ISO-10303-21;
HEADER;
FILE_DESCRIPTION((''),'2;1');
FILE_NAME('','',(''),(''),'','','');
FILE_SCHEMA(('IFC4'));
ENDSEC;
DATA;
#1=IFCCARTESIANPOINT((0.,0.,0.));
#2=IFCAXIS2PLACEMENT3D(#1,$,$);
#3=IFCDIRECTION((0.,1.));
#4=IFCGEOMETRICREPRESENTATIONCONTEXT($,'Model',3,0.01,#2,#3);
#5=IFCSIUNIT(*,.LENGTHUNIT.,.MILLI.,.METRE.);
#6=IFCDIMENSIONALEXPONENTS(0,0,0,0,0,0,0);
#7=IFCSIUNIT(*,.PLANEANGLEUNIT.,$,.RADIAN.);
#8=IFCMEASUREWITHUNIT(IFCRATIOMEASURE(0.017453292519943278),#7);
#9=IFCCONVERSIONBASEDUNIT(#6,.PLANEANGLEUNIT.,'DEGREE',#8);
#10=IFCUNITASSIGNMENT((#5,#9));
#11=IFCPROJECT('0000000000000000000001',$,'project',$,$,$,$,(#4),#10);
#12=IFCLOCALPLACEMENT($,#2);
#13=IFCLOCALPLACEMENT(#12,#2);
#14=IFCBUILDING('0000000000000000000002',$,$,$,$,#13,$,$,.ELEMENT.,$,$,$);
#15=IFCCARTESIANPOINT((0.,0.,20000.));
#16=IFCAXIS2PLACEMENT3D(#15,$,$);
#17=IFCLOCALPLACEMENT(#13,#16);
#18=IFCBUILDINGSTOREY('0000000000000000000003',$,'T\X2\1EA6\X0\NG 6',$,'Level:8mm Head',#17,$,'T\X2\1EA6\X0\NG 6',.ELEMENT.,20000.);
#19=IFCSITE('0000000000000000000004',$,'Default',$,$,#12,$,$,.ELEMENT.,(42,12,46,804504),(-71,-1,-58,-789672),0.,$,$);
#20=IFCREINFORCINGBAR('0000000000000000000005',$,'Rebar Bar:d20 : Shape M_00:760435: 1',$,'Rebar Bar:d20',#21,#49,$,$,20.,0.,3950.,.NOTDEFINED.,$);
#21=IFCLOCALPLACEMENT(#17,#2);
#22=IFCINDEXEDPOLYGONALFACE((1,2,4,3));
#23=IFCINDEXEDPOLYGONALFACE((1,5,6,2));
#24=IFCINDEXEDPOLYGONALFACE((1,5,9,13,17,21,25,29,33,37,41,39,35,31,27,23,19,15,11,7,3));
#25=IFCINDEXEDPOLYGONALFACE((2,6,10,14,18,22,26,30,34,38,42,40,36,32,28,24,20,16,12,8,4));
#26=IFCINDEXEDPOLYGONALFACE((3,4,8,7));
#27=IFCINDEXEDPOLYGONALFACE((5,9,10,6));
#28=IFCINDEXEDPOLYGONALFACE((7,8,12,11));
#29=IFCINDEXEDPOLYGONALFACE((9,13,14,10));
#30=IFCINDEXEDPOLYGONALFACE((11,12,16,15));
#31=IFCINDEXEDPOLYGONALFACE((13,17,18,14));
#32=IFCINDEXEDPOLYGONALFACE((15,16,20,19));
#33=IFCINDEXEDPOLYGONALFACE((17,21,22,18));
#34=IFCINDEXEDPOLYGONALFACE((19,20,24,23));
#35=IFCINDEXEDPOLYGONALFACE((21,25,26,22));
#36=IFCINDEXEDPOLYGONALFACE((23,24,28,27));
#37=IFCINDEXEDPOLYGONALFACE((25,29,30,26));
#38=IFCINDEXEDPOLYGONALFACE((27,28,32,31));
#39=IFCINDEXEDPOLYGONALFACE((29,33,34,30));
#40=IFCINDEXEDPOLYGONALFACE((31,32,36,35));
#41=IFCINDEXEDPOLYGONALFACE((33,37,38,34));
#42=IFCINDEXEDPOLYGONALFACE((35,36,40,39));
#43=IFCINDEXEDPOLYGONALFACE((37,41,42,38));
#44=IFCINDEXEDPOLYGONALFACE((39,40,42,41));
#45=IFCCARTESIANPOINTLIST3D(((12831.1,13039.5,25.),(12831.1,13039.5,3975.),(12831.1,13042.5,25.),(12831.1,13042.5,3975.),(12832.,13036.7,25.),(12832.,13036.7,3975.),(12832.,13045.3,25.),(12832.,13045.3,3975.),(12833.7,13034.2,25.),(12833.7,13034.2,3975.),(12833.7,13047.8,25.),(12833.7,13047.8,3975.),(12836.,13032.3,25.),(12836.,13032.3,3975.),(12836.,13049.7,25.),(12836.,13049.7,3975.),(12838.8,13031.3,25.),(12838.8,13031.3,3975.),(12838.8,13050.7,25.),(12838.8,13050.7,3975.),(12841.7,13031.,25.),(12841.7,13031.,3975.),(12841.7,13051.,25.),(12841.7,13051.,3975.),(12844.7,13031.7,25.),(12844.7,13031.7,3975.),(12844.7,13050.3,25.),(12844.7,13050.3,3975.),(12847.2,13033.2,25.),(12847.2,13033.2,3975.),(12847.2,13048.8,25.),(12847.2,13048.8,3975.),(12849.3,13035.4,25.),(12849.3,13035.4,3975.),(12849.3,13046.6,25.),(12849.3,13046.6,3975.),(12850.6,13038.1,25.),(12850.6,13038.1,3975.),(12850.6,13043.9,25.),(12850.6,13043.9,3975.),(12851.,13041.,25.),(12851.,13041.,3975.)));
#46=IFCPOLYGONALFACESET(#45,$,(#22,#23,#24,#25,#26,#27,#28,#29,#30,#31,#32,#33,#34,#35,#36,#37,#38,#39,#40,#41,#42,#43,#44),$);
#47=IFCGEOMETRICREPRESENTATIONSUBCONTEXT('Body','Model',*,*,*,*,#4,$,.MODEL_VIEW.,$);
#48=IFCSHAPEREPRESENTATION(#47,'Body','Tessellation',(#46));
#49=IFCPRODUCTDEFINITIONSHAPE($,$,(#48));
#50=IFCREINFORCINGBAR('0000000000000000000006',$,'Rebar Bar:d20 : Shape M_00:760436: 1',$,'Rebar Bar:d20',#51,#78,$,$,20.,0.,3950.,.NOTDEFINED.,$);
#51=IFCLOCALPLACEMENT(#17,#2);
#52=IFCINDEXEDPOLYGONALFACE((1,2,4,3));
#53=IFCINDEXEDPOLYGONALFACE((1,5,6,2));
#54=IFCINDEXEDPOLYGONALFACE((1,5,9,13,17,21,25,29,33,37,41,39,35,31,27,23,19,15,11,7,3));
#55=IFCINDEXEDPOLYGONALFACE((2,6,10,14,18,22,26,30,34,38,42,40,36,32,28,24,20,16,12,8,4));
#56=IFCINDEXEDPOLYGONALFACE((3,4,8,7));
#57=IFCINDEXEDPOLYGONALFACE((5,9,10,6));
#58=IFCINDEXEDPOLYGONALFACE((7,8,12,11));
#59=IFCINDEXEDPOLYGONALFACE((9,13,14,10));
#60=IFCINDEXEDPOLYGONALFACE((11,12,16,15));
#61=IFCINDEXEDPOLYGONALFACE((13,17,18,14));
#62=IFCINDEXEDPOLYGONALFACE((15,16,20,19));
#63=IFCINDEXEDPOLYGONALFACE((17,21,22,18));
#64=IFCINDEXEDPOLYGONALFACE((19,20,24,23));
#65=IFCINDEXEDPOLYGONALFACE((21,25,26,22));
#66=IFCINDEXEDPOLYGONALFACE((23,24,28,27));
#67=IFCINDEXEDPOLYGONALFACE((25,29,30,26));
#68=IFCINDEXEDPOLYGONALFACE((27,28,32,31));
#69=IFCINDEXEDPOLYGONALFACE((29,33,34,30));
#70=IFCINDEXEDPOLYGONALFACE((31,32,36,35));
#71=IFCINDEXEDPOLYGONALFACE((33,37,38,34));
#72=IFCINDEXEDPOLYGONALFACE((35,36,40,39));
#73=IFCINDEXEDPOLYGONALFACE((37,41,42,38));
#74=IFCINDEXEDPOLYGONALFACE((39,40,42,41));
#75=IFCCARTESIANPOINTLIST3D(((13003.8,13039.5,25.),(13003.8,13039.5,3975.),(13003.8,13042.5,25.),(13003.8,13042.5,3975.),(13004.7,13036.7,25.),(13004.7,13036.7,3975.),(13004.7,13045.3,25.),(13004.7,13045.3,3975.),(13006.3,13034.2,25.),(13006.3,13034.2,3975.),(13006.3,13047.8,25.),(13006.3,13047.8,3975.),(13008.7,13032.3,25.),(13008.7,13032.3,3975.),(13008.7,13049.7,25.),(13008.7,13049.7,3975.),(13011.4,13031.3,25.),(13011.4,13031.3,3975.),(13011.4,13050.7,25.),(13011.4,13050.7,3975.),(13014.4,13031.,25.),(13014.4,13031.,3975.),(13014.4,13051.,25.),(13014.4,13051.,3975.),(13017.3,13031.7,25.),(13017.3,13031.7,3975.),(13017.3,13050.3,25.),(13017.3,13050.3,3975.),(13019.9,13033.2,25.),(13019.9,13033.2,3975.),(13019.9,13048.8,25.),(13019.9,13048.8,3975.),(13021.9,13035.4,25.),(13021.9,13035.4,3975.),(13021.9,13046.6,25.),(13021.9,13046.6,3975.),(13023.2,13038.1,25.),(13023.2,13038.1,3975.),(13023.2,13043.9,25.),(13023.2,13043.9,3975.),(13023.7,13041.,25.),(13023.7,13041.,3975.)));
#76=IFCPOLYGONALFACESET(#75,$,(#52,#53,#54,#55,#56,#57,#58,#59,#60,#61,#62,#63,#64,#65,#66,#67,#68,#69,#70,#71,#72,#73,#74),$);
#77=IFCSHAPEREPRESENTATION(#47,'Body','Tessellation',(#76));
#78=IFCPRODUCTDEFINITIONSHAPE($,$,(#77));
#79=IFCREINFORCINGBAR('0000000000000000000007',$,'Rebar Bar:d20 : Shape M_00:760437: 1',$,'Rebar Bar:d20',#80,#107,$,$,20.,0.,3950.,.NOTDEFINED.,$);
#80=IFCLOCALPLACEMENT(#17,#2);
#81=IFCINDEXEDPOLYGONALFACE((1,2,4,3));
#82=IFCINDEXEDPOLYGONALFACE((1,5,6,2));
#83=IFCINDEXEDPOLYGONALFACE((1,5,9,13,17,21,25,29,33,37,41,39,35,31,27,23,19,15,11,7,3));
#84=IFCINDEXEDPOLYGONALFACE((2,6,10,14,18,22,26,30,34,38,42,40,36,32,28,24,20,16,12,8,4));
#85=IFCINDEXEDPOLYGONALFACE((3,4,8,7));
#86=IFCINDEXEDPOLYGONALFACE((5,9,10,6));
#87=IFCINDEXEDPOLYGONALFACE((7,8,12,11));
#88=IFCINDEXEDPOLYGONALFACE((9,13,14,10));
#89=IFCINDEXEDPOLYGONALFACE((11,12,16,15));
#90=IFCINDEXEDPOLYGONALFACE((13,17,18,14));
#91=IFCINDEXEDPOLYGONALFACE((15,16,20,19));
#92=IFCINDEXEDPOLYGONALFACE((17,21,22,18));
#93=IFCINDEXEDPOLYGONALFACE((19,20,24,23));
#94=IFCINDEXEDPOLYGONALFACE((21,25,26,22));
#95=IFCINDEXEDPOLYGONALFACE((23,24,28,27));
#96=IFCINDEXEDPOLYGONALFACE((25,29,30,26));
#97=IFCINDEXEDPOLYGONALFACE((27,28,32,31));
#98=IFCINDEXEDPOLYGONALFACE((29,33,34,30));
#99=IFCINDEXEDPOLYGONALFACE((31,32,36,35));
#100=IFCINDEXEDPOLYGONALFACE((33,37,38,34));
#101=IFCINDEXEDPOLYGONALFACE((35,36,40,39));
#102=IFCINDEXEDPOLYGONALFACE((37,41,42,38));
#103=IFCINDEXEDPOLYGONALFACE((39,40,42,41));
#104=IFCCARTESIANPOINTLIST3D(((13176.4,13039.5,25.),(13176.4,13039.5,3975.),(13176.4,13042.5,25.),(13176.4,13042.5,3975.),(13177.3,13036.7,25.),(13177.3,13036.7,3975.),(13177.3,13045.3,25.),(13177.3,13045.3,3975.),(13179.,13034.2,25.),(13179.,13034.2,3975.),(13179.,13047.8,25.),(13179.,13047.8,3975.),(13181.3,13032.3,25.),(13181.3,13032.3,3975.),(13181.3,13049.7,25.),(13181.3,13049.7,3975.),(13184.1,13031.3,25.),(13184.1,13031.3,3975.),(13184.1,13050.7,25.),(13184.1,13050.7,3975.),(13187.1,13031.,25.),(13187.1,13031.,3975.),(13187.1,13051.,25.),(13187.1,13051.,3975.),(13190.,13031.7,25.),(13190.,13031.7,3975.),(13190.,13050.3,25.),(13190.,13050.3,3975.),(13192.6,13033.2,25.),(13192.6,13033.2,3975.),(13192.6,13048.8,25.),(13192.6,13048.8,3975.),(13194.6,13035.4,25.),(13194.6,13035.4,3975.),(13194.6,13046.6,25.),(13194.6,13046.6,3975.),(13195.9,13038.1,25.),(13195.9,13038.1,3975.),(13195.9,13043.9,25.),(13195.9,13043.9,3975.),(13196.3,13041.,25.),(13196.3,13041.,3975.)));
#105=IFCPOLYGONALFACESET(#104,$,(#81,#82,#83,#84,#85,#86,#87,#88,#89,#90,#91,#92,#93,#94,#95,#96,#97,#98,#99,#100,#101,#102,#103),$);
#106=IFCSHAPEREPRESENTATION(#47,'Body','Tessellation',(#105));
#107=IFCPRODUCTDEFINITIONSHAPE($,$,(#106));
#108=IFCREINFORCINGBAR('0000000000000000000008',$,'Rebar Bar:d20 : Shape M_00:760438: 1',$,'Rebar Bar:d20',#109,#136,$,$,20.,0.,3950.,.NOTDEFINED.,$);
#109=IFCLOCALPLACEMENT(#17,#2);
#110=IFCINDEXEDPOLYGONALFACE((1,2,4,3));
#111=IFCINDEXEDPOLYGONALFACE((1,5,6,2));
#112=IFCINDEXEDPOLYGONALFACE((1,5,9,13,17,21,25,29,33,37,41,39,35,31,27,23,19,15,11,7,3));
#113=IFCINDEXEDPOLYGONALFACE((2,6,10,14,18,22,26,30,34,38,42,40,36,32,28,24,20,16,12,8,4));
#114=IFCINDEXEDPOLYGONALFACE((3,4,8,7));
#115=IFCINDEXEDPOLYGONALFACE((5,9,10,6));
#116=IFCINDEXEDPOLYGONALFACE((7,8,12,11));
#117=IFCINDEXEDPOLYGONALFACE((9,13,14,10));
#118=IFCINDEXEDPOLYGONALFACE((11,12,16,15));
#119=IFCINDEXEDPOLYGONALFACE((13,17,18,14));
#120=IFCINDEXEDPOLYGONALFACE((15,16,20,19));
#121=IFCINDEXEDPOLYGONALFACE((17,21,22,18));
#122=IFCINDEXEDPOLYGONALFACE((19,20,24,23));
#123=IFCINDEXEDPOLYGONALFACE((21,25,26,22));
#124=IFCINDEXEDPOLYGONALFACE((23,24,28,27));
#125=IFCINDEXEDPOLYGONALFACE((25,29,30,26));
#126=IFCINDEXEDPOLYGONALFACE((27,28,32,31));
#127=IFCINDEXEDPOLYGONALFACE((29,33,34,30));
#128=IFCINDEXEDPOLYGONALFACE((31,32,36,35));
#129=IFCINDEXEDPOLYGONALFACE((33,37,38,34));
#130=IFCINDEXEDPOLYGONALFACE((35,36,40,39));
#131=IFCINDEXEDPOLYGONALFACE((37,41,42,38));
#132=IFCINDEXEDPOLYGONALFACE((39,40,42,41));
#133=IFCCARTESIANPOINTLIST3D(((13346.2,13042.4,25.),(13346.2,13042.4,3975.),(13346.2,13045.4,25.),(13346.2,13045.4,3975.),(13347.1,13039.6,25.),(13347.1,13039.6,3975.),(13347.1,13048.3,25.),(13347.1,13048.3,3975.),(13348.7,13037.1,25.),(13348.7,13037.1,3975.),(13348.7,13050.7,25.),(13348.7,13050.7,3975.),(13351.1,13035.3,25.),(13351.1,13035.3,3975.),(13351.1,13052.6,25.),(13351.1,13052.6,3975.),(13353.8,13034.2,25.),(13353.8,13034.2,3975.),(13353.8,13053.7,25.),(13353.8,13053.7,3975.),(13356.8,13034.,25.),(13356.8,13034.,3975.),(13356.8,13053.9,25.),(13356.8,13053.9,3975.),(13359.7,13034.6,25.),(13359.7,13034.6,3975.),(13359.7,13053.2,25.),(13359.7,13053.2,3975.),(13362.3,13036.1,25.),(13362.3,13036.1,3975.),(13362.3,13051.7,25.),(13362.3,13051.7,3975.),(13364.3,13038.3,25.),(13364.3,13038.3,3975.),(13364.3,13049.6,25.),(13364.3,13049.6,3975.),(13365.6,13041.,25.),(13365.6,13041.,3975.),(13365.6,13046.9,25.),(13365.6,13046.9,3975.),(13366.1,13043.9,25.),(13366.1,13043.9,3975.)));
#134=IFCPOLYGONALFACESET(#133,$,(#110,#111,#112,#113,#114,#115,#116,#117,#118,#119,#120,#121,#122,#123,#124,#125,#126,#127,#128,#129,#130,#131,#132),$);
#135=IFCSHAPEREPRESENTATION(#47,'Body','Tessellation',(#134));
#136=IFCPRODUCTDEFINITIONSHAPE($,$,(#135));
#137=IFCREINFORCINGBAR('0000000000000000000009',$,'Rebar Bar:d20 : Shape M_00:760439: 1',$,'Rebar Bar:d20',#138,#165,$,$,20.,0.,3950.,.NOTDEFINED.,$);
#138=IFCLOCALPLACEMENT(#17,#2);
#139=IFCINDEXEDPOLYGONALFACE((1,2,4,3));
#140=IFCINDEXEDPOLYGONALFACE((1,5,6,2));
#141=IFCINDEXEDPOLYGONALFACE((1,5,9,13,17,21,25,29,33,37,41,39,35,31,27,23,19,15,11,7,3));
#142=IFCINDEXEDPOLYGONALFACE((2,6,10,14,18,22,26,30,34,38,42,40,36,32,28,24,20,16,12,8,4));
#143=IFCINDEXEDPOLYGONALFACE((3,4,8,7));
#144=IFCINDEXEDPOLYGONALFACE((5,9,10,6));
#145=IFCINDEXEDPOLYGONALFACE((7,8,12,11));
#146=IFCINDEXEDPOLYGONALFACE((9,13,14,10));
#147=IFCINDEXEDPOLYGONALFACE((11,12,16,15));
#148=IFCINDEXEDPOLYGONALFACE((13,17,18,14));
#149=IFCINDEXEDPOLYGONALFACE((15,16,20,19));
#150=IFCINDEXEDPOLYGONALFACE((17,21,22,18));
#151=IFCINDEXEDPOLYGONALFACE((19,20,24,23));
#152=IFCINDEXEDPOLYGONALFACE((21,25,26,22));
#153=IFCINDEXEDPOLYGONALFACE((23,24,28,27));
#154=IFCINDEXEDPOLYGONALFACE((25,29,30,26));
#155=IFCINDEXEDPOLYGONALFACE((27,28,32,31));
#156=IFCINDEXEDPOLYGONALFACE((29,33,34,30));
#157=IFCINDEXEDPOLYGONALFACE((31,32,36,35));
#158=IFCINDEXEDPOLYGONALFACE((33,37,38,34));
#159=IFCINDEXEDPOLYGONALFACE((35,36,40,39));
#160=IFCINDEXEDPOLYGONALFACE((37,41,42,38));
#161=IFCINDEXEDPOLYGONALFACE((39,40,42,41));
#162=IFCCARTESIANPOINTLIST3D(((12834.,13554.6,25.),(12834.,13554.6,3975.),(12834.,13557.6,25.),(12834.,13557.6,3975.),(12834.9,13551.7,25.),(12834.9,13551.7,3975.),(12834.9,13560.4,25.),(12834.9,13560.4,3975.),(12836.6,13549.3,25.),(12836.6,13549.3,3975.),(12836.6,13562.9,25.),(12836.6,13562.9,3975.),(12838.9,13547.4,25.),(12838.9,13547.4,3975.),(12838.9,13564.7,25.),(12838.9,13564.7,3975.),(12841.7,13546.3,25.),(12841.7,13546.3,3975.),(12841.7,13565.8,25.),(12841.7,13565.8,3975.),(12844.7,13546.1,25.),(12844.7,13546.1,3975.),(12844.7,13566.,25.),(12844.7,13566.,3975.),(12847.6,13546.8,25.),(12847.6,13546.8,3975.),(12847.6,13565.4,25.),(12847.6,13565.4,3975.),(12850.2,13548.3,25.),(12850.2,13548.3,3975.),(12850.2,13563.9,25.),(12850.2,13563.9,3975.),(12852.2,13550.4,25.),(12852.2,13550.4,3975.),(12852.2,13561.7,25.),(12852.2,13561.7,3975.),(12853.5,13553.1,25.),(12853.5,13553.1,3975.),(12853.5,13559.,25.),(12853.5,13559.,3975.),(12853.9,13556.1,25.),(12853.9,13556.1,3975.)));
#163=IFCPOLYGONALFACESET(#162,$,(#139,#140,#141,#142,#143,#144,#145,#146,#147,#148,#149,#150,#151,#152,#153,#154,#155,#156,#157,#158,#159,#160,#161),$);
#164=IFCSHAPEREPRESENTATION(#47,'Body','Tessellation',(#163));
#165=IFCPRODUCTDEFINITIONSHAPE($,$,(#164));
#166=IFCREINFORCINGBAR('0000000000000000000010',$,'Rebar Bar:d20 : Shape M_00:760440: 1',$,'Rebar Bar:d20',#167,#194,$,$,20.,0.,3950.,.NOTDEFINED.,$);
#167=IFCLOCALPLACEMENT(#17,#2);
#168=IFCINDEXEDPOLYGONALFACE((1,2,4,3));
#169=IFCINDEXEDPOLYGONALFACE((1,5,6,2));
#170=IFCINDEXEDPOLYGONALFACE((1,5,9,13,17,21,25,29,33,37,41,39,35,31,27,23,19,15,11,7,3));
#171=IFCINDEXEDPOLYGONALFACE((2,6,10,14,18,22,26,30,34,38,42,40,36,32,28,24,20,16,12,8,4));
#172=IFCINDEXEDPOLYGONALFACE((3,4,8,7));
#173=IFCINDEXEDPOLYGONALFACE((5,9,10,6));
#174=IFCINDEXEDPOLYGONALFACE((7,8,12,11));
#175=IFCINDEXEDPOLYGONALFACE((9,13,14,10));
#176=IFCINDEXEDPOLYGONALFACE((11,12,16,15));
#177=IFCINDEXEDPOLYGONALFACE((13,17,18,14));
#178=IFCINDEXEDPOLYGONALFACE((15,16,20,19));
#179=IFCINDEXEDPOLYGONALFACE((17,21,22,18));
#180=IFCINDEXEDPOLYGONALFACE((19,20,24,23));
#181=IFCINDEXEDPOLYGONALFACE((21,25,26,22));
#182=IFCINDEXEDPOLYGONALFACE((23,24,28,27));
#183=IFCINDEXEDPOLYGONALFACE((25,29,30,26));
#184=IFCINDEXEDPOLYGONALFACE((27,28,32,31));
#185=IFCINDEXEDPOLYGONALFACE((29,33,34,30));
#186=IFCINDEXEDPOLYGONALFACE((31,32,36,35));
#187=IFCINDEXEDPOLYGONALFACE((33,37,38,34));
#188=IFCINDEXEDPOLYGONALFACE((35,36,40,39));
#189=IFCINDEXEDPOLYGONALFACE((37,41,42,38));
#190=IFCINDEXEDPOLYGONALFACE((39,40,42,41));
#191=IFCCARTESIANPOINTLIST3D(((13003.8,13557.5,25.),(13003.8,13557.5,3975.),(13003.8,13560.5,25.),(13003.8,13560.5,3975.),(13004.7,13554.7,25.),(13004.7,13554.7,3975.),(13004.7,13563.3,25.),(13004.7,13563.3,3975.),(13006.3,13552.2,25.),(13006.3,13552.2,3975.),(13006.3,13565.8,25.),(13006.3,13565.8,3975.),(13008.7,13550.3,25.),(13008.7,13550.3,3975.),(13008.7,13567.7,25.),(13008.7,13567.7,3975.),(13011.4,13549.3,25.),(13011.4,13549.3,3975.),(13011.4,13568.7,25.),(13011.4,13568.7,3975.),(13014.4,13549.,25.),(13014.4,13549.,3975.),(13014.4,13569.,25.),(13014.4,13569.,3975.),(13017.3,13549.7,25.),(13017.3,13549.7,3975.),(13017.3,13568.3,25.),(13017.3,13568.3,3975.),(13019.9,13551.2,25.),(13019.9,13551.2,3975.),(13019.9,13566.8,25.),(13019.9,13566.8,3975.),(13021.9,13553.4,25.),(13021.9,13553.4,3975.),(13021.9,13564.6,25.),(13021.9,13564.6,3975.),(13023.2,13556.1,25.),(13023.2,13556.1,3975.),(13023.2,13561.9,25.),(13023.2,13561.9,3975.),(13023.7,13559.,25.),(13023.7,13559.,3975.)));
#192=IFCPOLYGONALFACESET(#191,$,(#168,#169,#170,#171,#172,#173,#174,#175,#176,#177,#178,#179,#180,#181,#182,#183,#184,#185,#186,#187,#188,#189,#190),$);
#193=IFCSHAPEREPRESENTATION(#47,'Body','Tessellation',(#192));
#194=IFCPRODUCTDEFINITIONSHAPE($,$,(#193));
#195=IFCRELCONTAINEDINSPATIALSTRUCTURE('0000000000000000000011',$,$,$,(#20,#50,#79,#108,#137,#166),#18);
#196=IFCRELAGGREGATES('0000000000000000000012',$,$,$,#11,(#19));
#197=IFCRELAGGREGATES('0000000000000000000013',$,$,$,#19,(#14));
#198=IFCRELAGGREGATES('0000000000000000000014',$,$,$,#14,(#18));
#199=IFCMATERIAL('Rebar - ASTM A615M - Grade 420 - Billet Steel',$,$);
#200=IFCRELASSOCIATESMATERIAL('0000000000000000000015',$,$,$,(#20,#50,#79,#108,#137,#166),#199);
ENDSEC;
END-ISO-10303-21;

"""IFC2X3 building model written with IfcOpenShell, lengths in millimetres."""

from ifc_helpers import new_model, entity, si_unit, converted_unit, direction, frame, origin, place, context, subcontext, project, spatial, material, element, save


model = new_model("IFC2X3")

# Units and contexts
model_context = context("Model", 3, precision=0.01, world=origin(), true_north=direction((0.0, 1.0)))
body_context = subcontext(model_context, "Body", "Model", "MODEL_VIEW")
ifc_project = project(units=[si_unit("LENGTHUNIT", "METRE", prefix="MILLI"), converted_unit("PLANEANGLEUNIT", "DEGREE", entity("IfcRatioMeasure", 0.017453292519943278), si_unit("PLANEANGLEUNIT", "RADIAN"), dimensions=[0, 0, 0, 0, 0, 0, 0])], contexts=[model_context])

# Site, building, storey
site_placement = place(None, origin())
site = spatial("IfcSite", under=ifc_project, at=site_placement, Name="Default", CompositionType="ELEMENT", RefLatitude=(42, 12, 46, 804504), RefLongitude=(-71, -1, -58, -789672), RefElevation=0.0)
building_placement = place(site_placement, origin())
building = spatial("IfcBuilding", under=site, at=building_placement, CompositionType="ELEMENT")
storey_placement = place(building_placement, frame((0.0, 0.0, 20000.0)))
storey = spatial("IfcBuildingStorey", under=building, at=storey_placement, Name="TẦNG 6", ObjectType="Level:8mm Head", LongName="TẦNG 6", CompositionType="ELEMENT", Elevation=20000.0)

# Reinforcing bars
ifc_material = material(Name="Rebar - ASTM A615M - Grade 420 - Billet Steel")
reinforcing_bar_1_placement = place(storey_placement, origin())
element("IfcReinforcingBar", 1, at=reinforcing_bar_1_placement, inside=storey, material=ifc_material, Name="Rebar Bar:d20 : Shape M_00:760435: 1", ObjectType="Rebar Bar:d20", BarLength=3950.0, BarRole="NOTDEFINED", CrossSectionArea=0.0, NominalDiameter=20.0, context=body_context, shape_type="AdvancedSweptSolid", body=[
    entity("IfcSweptDiskSolid", entity("IfcCompositeCurve", [entity("IfcCompositeCurveSegment", "CONTINUOUS", True, entity("IfcPolyline", [entity("IfcCartesianPoint", [12841.0, 13041.0, 25.0]), entity("IfcCartesianPoint", [12841.0, 13041.0, 3975.0])]))], False), 10.0, None, 0.0, 1.0),
])
reinforcing_bar_2_placement = place(storey_placement, origin())
element("IfcReinforcingBar", 2, at=reinforcing_bar_2_placement, inside=storey, material=ifc_material, Name="Rebar Bar:d20 : Shape M_00:760436: 1", ObjectType="Rebar Bar:d20", BarLength=3950.0, BarRole="NOTDEFINED", CrossSectionArea=0.0, NominalDiameter=20.0, context=body_context, shape_type="AdvancedSweptSolid", body=[
    entity("IfcSweptDiskSolid", entity("IfcCompositeCurve", [entity("IfcCompositeCurveSegment", "CONTINUOUS", True, entity("IfcPolyline", [entity("IfcCartesianPoint", [13013.7, 13041.0, 25.0]), entity("IfcCartesianPoint", [13013.7, 13041.0, 3975.0])]))], False), 10.0, None, 0.0, 1.0),
])
reinforcing_bar_3_placement = place(storey_placement, origin())
element("IfcReinforcingBar", 3, at=reinforcing_bar_3_placement, inside=storey, material=ifc_material, Name="Rebar Bar:d20 : Shape M_00:760437: 1", ObjectType="Rebar Bar:d20", BarLength=3950.0, BarRole="NOTDEFINED", CrossSectionArea=0.0, NominalDiameter=20.0, context=body_context, shape_type="AdvancedSweptSolid", body=[
    entity("IfcSweptDiskSolid", entity("IfcCompositeCurve", [entity("IfcCompositeCurveSegment", "CONTINUOUS", True, entity("IfcPolyline", [entity("IfcCartesianPoint", [13186.3, 13041.0, 25.0]), entity("IfcCartesianPoint", [13186.3, 13041.0, 3975.0])]))], False), 10.0, None, 0.0, 1.0),
])
reinforcing_bar_4_placement = place(storey_placement, origin())
element("IfcReinforcingBar", 4, at=reinforcing_bar_4_placement, inside=storey, material=ifc_material, Name="Rebar Bar:d20 : Shape M_00:760438: 1", ObjectType="Rebar Bar:d20", BarLength=3950.0, BarRole="NOTDEFINED", CrossSectionArea=0.0, NominalDiameter=20.0, context=body_context, shape_type="AdvancedSweptSolid", body=[
    entity("IfcSweptDiskSolid", entity("IfcCompositeCurve", [entity("IfcCompositeCurveSegment", "CONTINUOUS", True, entity("IfcPolyline", [entity("IfcCartesianPoint", [13356.1, 13043.9, 25.0]), entity("IfcCartesianPoint", [13356.1, 13043.9, 3975.0])]))], False), 10.0, None, 0.0, 1.0),
])
reinforcing_bar_5_placement = place(storey_placement, origin())
element("IfcReinforcingBar", 5, at=reinforcing_bar_5_placement, inside=storey, material=ifc_material, Name="Rebar Bar:d20 : Shape M_00:760439: 1", ObjectType="Rebar Bar:d20", BarLength=3950.0, BarRole="NOTDEFINED", CrossSectionArea=0.0, NominalDiameter=20.0, context=body_context, shape_type="AdvancedSweptSolid", body=[
    entity("IfcSweptDiskSolid", entity("IfcCompositeCurve", [entity("IfcCompositeCurveSegment", "CONTINUOUS", True, entity("IfcPolyline", [entity("IfcCartesianPoint", [12843.9, 13556.1, 25.0]), entity("IfcCartesianPoint", [12843.9, 13556.1, 3975.0])]))], False), 10.0, None, 0.0, 1.0),
])
reinforcing_bar_6_placement = place(storey_placement, origin())
element("IfcReinforcingBar", 6, at=reinforcing_bar_6_placement, inside=storey, material=ifc_material, Name="Rebar Bar:d20 : Shape M_00:760440: 1", ObjectType="Rebar Bar:d20", BarLength=3950.0, BarRole="NOTDEFINED", CrossSectionArea=0.0, NominalDiameter=20.0, context=body_context, shape_type="AdvancedSweptSolid", body=[
    entity("IfcSweptDiskSolid", entity("IfcCompositeCurve", [entity("IfcCompositeCurveSegment", "CONTINUOUS", True, entity("IfcPolyline", [entity("IfcCartesianPoint", [13013.7, 13559.0, 25.0]), entity("IfcCartesianPoint", [13013.7, 13559.0, 3975.0])]))], False), 10.0, None, 0.0, 1.0),
])

save(model, "model.ifc")
